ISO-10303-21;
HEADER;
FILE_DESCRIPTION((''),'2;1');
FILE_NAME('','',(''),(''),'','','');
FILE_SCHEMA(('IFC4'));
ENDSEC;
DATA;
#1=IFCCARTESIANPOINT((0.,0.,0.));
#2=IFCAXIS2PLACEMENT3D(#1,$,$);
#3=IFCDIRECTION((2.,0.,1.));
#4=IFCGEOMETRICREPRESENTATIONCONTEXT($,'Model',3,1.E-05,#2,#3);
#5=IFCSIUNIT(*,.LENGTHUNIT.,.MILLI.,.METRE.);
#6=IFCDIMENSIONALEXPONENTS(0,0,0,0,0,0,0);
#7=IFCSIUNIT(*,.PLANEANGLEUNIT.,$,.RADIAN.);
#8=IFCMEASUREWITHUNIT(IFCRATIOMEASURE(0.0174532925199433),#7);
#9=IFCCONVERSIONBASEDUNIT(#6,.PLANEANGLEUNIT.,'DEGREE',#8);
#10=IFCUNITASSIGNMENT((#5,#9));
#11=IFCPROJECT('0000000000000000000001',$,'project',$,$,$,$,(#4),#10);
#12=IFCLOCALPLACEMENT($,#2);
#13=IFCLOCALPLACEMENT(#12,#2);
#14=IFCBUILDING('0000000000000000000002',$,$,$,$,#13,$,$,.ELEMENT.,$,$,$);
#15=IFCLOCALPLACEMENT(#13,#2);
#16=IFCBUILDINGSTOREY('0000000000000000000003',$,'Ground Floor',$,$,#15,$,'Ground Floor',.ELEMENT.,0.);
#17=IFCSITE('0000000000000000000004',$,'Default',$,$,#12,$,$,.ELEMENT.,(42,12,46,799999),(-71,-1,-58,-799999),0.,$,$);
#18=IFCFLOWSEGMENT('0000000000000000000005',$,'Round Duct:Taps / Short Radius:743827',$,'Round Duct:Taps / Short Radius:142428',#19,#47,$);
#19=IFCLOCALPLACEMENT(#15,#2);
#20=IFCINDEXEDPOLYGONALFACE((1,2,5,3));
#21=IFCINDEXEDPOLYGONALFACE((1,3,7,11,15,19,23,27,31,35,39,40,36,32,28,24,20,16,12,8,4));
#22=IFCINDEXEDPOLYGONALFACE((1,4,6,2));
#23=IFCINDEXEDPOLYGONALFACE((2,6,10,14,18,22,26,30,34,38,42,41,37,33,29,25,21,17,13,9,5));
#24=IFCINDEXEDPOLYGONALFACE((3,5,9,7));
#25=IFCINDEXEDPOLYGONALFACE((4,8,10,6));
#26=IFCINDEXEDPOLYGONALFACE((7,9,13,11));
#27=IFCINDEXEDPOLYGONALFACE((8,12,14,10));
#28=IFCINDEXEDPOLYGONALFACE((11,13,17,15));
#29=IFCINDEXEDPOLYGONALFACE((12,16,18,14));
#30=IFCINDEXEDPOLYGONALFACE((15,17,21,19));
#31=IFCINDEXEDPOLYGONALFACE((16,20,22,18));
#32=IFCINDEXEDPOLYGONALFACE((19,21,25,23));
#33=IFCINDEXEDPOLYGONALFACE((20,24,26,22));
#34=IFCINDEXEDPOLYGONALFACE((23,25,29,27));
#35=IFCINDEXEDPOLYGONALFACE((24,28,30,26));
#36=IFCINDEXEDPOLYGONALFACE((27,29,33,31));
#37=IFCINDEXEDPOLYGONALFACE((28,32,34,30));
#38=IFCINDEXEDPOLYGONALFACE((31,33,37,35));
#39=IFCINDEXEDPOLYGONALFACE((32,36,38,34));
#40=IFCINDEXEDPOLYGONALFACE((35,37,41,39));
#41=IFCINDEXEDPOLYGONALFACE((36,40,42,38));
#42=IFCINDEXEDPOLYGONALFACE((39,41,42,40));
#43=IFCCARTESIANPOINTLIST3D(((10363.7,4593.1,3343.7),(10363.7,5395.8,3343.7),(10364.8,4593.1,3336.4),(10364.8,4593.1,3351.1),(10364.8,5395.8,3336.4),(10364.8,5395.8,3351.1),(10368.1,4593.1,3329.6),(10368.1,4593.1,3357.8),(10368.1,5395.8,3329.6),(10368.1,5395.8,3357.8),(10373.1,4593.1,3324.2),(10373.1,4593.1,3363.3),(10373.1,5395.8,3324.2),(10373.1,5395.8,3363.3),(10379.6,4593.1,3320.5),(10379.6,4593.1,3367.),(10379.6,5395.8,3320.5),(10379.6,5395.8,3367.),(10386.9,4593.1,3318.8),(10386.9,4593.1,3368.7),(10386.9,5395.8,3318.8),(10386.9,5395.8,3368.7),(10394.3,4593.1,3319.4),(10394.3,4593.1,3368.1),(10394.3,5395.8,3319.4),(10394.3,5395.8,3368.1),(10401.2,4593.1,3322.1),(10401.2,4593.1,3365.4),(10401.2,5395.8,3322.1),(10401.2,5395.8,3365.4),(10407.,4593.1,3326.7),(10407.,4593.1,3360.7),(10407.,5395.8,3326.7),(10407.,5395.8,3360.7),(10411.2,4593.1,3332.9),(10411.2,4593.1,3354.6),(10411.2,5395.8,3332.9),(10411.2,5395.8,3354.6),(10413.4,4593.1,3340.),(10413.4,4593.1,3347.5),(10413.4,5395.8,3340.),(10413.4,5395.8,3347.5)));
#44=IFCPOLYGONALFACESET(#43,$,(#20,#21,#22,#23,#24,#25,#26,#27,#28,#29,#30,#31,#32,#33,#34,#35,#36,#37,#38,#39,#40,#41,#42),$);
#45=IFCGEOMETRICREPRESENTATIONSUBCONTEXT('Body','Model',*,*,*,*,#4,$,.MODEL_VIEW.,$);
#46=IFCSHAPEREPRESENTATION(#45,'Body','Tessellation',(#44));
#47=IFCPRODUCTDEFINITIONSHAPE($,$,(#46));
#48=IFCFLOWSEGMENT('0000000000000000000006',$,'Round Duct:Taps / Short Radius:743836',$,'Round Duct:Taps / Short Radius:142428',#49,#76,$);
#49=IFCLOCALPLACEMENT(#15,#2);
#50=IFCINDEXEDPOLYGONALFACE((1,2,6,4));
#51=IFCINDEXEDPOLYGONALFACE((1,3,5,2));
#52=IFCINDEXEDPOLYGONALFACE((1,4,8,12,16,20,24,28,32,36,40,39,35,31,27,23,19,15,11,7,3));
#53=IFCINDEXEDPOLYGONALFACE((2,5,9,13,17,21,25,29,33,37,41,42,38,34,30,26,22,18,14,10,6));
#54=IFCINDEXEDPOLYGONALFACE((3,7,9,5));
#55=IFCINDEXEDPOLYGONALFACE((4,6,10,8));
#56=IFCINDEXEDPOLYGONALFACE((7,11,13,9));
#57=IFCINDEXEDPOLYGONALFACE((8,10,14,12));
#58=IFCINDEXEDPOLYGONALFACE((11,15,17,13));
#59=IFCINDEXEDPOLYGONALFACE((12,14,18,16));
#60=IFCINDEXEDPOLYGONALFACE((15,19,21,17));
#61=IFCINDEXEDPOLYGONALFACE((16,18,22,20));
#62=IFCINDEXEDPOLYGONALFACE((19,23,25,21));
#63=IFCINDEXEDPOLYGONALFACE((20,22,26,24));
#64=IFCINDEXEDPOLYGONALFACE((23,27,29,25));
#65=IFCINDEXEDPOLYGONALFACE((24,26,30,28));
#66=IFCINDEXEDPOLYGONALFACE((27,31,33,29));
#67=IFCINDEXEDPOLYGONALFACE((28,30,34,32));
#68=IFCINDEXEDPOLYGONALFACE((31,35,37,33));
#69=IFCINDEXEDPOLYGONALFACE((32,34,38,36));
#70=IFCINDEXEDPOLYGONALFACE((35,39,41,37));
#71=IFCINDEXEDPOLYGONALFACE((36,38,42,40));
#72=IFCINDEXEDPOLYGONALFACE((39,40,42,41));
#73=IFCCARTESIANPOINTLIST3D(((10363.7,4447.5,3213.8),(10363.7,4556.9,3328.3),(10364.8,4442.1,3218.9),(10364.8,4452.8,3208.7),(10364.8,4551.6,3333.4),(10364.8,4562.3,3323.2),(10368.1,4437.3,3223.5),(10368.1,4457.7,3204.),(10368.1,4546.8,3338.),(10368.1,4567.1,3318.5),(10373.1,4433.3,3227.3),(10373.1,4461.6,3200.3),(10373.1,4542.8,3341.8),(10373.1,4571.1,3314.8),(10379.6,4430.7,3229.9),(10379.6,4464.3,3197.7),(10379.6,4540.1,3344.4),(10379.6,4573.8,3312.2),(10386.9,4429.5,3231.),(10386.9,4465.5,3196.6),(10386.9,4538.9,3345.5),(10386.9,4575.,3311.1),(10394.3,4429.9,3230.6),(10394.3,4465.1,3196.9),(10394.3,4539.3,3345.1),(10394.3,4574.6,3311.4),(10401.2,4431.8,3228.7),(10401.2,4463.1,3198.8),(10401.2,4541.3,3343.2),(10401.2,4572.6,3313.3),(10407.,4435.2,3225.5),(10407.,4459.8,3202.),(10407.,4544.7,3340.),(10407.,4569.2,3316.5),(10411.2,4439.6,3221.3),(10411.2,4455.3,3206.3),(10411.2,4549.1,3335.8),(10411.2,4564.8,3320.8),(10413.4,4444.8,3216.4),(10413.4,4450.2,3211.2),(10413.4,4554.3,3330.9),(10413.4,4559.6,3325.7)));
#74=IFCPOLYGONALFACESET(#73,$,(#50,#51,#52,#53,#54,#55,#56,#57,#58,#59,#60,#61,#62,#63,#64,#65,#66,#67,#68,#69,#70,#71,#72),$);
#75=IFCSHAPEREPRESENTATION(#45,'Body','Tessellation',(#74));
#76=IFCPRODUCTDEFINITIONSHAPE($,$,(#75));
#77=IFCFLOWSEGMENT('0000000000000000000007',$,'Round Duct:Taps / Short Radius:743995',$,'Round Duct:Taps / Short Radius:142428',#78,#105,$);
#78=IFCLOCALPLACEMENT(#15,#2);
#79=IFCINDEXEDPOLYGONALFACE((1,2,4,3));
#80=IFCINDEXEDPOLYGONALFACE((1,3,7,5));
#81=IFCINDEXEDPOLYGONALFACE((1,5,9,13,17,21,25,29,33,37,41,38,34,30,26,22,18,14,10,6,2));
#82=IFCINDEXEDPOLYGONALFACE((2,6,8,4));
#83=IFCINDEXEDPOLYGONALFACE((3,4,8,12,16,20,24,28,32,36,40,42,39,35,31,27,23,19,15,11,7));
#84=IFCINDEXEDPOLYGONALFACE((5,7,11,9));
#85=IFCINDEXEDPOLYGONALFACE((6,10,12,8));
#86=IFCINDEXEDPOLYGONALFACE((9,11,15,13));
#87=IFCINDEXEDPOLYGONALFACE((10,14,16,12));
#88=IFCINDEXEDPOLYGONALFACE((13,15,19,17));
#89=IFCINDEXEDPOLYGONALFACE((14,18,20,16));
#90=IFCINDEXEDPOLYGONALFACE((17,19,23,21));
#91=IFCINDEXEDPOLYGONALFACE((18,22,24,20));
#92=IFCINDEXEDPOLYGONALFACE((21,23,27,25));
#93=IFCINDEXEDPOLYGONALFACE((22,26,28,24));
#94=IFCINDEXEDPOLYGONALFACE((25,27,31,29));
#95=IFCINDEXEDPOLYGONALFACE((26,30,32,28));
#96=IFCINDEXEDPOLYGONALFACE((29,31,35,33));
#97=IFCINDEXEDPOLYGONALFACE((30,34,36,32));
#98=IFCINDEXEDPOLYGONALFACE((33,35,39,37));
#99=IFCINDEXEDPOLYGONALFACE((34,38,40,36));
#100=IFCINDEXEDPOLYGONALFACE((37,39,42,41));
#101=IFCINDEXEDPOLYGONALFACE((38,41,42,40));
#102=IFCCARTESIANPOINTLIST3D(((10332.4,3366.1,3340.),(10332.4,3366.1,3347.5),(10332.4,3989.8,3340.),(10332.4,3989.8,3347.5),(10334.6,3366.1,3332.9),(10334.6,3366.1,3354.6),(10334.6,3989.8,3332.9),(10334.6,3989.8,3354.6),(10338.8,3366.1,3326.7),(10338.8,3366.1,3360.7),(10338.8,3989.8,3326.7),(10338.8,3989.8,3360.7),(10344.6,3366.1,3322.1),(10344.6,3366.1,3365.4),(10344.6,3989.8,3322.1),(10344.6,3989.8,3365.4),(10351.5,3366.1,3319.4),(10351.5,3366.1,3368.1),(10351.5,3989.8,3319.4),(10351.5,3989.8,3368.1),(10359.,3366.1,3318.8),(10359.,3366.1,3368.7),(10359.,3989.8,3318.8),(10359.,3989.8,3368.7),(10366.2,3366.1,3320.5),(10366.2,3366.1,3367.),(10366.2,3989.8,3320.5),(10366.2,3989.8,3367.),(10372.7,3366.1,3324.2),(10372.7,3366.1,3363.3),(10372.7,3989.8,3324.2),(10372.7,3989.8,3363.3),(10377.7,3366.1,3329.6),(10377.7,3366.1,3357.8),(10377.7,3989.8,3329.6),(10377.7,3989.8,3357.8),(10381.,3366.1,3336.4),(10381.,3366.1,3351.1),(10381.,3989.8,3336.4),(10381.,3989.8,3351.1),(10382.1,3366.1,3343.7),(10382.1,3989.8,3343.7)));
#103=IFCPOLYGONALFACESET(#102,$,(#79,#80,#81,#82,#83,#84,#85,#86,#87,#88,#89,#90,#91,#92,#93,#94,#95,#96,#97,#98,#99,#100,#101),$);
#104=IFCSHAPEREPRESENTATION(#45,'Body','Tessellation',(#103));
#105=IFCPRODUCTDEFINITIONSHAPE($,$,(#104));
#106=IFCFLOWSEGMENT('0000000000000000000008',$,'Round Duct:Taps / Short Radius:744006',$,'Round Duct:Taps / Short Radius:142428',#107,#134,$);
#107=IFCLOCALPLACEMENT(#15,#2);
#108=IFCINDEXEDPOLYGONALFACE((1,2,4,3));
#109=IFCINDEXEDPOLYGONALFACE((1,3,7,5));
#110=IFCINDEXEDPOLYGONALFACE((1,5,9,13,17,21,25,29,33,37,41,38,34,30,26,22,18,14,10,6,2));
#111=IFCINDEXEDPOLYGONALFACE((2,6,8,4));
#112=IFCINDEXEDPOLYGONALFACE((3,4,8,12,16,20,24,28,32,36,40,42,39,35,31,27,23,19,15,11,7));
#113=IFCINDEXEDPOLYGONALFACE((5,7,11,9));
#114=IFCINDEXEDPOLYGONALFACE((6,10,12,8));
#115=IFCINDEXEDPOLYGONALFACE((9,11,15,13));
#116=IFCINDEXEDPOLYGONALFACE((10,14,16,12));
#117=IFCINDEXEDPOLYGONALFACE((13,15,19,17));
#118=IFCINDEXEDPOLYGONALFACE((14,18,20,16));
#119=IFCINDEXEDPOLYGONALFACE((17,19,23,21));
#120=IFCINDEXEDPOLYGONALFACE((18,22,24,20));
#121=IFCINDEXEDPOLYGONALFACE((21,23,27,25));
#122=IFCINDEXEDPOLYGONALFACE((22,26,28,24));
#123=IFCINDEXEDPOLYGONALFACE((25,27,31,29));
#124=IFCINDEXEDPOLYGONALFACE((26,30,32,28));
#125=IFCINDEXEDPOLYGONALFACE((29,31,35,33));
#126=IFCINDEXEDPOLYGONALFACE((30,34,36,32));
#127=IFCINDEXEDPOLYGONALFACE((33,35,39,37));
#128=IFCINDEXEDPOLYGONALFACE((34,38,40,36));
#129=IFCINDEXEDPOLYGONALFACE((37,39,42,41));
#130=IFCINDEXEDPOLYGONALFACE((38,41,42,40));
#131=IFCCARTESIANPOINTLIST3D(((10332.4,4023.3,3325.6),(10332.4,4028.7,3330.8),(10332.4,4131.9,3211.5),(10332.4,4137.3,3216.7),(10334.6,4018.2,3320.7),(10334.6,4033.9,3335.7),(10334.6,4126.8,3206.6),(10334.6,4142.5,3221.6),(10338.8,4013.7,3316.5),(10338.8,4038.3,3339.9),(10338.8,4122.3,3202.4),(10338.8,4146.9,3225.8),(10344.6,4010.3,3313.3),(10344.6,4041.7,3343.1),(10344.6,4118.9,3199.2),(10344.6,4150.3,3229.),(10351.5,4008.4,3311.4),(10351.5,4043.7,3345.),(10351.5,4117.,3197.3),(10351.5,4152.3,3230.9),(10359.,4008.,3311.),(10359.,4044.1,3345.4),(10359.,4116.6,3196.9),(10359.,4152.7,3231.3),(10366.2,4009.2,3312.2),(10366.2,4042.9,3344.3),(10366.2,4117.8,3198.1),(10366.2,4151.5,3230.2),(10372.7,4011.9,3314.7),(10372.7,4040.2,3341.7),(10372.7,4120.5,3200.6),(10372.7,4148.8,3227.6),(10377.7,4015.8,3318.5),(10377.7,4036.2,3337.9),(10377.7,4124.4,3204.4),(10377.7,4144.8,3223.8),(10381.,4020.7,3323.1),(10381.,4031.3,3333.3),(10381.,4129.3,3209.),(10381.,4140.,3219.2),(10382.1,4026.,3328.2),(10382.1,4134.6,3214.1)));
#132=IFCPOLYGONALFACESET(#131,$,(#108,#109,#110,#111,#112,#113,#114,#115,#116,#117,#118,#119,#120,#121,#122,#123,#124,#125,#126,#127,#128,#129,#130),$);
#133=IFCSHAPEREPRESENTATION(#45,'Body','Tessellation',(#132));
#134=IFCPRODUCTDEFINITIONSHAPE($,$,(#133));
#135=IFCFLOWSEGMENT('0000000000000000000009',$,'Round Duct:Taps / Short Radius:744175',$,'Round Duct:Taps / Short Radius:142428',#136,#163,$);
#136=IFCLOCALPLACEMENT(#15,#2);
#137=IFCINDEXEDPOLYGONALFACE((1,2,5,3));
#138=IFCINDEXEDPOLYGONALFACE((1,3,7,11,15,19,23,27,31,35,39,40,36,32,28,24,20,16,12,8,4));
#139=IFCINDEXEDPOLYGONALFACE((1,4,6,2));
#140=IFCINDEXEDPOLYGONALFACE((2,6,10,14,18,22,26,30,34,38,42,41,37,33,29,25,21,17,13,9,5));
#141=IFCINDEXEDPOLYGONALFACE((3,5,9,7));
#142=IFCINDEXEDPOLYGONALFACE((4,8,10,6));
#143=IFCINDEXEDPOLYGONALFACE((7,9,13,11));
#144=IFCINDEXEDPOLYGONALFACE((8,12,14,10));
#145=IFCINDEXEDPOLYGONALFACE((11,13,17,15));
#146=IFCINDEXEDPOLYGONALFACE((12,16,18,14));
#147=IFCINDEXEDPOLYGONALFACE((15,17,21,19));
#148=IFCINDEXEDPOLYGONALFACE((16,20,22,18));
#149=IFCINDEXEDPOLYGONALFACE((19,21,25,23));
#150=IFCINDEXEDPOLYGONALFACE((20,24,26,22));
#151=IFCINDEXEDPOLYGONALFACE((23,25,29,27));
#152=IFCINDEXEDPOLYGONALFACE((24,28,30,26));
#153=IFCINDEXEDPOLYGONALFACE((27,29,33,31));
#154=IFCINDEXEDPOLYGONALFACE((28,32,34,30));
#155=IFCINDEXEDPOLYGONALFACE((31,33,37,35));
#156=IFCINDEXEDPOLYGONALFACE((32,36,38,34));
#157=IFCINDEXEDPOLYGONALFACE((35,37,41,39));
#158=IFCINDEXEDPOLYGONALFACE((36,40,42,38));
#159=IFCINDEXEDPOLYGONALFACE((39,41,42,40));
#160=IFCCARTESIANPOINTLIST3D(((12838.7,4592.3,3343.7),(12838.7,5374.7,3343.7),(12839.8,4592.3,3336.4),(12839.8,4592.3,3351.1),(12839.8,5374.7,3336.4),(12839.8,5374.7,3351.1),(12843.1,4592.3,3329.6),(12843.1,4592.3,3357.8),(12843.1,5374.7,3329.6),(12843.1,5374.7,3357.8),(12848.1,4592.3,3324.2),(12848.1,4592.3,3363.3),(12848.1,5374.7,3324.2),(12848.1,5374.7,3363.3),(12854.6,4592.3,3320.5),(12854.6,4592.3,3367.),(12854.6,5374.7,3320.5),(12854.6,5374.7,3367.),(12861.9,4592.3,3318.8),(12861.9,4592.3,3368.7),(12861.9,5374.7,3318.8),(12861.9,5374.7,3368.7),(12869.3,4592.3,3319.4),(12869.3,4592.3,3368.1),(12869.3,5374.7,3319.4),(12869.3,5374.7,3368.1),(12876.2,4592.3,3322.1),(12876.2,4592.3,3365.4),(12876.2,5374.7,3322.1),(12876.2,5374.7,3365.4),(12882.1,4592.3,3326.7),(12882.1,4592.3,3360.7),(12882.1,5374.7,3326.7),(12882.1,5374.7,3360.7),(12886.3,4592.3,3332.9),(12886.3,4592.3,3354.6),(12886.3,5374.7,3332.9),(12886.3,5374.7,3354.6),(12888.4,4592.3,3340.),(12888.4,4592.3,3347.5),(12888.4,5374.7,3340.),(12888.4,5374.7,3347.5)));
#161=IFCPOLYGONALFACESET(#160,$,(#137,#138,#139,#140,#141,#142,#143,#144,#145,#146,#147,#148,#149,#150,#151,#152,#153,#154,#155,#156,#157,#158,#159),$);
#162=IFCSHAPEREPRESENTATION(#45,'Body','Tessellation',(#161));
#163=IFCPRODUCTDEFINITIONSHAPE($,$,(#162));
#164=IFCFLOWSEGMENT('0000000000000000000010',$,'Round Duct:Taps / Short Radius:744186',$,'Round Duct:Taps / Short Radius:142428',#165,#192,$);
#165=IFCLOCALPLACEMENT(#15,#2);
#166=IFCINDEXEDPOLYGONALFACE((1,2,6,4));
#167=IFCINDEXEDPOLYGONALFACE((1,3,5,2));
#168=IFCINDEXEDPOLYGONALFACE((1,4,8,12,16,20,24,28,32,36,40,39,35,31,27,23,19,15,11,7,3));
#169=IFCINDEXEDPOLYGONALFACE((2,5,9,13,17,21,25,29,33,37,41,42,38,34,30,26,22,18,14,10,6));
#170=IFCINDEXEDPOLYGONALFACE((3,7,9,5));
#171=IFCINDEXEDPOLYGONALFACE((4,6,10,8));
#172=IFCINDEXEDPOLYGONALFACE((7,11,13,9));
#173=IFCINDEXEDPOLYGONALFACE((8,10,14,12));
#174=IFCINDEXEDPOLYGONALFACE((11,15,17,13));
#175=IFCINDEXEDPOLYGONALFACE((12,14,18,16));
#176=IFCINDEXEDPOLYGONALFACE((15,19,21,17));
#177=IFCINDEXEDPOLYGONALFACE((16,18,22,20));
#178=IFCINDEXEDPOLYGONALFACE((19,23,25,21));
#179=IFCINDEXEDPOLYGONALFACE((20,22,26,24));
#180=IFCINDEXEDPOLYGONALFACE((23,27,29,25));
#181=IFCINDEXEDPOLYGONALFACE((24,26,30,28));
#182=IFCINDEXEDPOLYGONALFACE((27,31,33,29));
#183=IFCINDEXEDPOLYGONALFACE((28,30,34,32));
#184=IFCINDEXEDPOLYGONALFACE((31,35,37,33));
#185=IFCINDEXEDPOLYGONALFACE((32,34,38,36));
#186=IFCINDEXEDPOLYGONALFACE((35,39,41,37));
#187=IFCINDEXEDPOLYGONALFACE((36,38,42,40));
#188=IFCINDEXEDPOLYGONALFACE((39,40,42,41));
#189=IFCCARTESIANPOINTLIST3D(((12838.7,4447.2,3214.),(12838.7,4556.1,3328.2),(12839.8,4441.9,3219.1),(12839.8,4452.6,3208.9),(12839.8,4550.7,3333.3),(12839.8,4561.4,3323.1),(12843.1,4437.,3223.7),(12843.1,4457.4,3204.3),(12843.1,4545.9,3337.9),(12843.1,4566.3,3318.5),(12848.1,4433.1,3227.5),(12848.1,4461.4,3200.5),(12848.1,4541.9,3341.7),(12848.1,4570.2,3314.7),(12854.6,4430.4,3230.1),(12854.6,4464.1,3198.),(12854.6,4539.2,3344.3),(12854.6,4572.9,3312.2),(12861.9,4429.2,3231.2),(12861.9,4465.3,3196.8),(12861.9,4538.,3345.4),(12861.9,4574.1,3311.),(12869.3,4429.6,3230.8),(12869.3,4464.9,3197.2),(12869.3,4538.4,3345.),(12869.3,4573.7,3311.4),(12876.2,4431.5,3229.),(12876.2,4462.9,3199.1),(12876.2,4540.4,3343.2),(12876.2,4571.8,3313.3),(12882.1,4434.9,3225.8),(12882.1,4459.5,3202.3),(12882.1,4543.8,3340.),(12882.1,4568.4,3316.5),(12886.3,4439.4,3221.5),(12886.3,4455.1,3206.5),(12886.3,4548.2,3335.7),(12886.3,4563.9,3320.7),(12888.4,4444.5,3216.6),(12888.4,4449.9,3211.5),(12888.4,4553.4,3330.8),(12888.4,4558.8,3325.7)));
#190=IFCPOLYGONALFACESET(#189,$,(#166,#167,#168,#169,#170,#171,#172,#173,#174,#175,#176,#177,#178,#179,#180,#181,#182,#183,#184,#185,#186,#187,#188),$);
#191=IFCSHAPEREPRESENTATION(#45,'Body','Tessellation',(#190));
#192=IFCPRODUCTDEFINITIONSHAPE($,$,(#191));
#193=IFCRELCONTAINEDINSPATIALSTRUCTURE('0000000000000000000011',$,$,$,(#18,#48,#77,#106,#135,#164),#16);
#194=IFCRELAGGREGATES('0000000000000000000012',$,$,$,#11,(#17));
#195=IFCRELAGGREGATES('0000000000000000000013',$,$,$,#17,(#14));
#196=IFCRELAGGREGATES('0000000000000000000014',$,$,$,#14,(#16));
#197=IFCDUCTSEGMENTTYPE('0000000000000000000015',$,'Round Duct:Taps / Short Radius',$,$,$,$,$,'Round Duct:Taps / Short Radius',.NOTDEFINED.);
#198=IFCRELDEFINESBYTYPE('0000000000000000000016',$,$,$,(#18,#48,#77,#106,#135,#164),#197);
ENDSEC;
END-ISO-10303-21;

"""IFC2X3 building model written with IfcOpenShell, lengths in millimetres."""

from ifc_helpers import new_model, entity, si_unit, converted_unit, direction, frame, frame_2d, origin, origin_2d_with_axis, place, context, subcontext, project, spatial, circle, extrude, type_object, element, save


model = new_model("IFC2X3")

# Units and contexts
model_context = context("Model", 3, precision=1e-05, world=origin(), true_north=direction((2.0, 0.0, 1.0)))
body_context = subcontext(model_context, "Body", "Model", "MODEL_VIEW")
ifc_project = project(units=[si_unit("LENGTHUNIT", "METRE", prefix="MILLI"), converted_unit("PLANEANGLEUNIT", "DEGREE", entity("IfcRatioMeasure", 0.0174532925199433), si_unit("PLANEANGLEUNIT", "RADIAN"), dimensions=[0, 0, 0, 0, 0, 0, 0])], contexts=[model_context])

# Site, building, storey
site_placement = place(None, origin())
site = spatial("IfcSite", under=ifc_project, at=site_placement, Name="Default", CompositionType="ELEMENT", RefLatitude=(42, 12, 46, 799999), RefLongitude=(-71, -1, -58, -799999), RefElevation=0.0)
building_placement = place(site_placement, origin())
building = spatial("IfcBuilding", under=site, at=building_placement, CompositionType="ELEMENT")
storey_placement = place(building_placement, origin())
storey = spatial("IfcBuildingStorey", under=building, at=storey_placement, Name="Ground Floor", LongName="Ground Floor", CompositionType="ELEMENT", Elevation=0.0)

# Flow segments
duct_segment_type = type_object("IfcDuctSegmentType", Name="Round Duct:Taps / Short Radius", ElementType="Round Duct:Taps / Short Radius", PredefinedType="NOTDEFINED")
flow_segment_1_placement = place(storey_placement, origin())
element("IfcFlowSegment", 1, at=flow_segment_1_placement, inside=storey, type_object=duct_segment_type, Name="Round Duct:Taps / Short Radius:743827", ObjectType="Round Duct:Taps / Short Radius:142428", context=body_context, shape_type="SweptSolid", body=[
    extrude(circle(Radius=25.0, at=frame_2d((0.0, 0.0), x_axis=(1.0, 0.0))), frame((10388.7, 4593.1, 3343.7), z_axis=(0.0, 1.0, 0.0), x_axis=(-1.0, 0.0, 0.0)), (0.0, 0.0, 1.0), 802.7),
])
flow_segment_2_placement = place(storey_placement, origin())
element("IfcFlowSegment", 2, at=flow_segment_2_placement, inside=storey, type_object=duct_segment_type, Name="Round Duct:Taps / Short Radius:743836", ObjectType="Round Duct:Taps / Short Radius:142428", context=body_context, shape_type="SweptSolid", body=[
    extrude(circle(Radius=25.0, at=frame_2d((0.0, 0.0), x_axis=(1.0, 0.0))), frame((10388.7, 4447.5, 3213.8), z_axis=(0.0, 0.691076, 0.722782), x_axis=(-1.0, 0.0, 0.0)), (0.0, 0.0, 1.0), 158.4),
])
flow_segment_3_placement = place(storey_placement, origin())
element("IfcFlowSegment", 3, at=flow_segment_3_placement, inside=storey, type_object=duct_segment_type, Name="Round Duct:Taps / Short Radius:743995", ObjectType="Round Duct:Taps / Short Radius:142428", context=body_context, shape_type="SweptSolid", body=[
    extrude(circle(Radius=25.0, at=origin_2d_with_axis()), frame((10357.1, 3366.1, 3343.7), z_axis=(0.0, 1.0, 0.0), x_axis=(1.0, 0.0, 0.0)), (0.0, 0.0, 1.0), 623.7),
])
flow_segment_4_placement = place(storey_placement, origin())
element("IfcFlowSegment", 4, at=flow_segment_4_placement, inside=storey, type_object=duct_segment_type, Name="Round Duct:Taps / Short Radius:744006", ObjectType="Round Duct:Taps / Short Radius:142428", context=body_context, shape_type="SweptSolid", body=[
    extrude(circle(Radius=25.0, at=frame_2d((0.0, 0.0), x_axis=(1.0, 0.0))), frame((10357.1, 4026.0, 3328.2), z_axis=(0.0, 0.689533, -0.724254), x_axis=(1.0, 0.0, 0.0)), (0.0, 0.0, 1.0), 157.5),
])
flow_segment_5_placement = place(storey_placement, origin())
element("IfcFlowSegment", 5, at=flow_segment_5_placement, inside=storey, type_object=duct_segment_type, Name="Round Duct:Taps / Short Radius:744175", ObjectType="Round Duct:Taps / Short Radius:142428", context=body_context, shape_type="SweptSolid", body=[
    extrude(circle(Radius=25.0, at=frame_2d((0.0, 0.0), x_axis=(1.0, 0.0))), frame((12863.7, 4592.3, 3343.7), z_axis=(0.0, 1.0, 0.0), x_axis=(-1.0, 0.0, 0.0)), (0.0, 0.0, 1.0), 782.5),
])
flow_segment_6_placement = place(storey_placement, origin())
element("IfcFlowSegment", 6, at=flow_segment_6_placement, inside=storey, type_object=duct_segment_type, Name="Round Duct:Taps / Short Radius:744186", ObjectType="Round Duct:Taps / Short Radius:142428", context=body_context, shape_type="SweptSolid", body=[
    extrude(circle(Radius=25.0, at=frame_2d((0.0, 0.0), x_axis=(1.0, 0.0))), frame((12863.7, 4447.2, 3214.0), z_axis=(0.0, 0.689966, 0.723842), x_axis=(-1.0, 0.0, 0.0)), (0.0, 0.0, 1.0), 157.8),
])

save(model, "model.ifc")
